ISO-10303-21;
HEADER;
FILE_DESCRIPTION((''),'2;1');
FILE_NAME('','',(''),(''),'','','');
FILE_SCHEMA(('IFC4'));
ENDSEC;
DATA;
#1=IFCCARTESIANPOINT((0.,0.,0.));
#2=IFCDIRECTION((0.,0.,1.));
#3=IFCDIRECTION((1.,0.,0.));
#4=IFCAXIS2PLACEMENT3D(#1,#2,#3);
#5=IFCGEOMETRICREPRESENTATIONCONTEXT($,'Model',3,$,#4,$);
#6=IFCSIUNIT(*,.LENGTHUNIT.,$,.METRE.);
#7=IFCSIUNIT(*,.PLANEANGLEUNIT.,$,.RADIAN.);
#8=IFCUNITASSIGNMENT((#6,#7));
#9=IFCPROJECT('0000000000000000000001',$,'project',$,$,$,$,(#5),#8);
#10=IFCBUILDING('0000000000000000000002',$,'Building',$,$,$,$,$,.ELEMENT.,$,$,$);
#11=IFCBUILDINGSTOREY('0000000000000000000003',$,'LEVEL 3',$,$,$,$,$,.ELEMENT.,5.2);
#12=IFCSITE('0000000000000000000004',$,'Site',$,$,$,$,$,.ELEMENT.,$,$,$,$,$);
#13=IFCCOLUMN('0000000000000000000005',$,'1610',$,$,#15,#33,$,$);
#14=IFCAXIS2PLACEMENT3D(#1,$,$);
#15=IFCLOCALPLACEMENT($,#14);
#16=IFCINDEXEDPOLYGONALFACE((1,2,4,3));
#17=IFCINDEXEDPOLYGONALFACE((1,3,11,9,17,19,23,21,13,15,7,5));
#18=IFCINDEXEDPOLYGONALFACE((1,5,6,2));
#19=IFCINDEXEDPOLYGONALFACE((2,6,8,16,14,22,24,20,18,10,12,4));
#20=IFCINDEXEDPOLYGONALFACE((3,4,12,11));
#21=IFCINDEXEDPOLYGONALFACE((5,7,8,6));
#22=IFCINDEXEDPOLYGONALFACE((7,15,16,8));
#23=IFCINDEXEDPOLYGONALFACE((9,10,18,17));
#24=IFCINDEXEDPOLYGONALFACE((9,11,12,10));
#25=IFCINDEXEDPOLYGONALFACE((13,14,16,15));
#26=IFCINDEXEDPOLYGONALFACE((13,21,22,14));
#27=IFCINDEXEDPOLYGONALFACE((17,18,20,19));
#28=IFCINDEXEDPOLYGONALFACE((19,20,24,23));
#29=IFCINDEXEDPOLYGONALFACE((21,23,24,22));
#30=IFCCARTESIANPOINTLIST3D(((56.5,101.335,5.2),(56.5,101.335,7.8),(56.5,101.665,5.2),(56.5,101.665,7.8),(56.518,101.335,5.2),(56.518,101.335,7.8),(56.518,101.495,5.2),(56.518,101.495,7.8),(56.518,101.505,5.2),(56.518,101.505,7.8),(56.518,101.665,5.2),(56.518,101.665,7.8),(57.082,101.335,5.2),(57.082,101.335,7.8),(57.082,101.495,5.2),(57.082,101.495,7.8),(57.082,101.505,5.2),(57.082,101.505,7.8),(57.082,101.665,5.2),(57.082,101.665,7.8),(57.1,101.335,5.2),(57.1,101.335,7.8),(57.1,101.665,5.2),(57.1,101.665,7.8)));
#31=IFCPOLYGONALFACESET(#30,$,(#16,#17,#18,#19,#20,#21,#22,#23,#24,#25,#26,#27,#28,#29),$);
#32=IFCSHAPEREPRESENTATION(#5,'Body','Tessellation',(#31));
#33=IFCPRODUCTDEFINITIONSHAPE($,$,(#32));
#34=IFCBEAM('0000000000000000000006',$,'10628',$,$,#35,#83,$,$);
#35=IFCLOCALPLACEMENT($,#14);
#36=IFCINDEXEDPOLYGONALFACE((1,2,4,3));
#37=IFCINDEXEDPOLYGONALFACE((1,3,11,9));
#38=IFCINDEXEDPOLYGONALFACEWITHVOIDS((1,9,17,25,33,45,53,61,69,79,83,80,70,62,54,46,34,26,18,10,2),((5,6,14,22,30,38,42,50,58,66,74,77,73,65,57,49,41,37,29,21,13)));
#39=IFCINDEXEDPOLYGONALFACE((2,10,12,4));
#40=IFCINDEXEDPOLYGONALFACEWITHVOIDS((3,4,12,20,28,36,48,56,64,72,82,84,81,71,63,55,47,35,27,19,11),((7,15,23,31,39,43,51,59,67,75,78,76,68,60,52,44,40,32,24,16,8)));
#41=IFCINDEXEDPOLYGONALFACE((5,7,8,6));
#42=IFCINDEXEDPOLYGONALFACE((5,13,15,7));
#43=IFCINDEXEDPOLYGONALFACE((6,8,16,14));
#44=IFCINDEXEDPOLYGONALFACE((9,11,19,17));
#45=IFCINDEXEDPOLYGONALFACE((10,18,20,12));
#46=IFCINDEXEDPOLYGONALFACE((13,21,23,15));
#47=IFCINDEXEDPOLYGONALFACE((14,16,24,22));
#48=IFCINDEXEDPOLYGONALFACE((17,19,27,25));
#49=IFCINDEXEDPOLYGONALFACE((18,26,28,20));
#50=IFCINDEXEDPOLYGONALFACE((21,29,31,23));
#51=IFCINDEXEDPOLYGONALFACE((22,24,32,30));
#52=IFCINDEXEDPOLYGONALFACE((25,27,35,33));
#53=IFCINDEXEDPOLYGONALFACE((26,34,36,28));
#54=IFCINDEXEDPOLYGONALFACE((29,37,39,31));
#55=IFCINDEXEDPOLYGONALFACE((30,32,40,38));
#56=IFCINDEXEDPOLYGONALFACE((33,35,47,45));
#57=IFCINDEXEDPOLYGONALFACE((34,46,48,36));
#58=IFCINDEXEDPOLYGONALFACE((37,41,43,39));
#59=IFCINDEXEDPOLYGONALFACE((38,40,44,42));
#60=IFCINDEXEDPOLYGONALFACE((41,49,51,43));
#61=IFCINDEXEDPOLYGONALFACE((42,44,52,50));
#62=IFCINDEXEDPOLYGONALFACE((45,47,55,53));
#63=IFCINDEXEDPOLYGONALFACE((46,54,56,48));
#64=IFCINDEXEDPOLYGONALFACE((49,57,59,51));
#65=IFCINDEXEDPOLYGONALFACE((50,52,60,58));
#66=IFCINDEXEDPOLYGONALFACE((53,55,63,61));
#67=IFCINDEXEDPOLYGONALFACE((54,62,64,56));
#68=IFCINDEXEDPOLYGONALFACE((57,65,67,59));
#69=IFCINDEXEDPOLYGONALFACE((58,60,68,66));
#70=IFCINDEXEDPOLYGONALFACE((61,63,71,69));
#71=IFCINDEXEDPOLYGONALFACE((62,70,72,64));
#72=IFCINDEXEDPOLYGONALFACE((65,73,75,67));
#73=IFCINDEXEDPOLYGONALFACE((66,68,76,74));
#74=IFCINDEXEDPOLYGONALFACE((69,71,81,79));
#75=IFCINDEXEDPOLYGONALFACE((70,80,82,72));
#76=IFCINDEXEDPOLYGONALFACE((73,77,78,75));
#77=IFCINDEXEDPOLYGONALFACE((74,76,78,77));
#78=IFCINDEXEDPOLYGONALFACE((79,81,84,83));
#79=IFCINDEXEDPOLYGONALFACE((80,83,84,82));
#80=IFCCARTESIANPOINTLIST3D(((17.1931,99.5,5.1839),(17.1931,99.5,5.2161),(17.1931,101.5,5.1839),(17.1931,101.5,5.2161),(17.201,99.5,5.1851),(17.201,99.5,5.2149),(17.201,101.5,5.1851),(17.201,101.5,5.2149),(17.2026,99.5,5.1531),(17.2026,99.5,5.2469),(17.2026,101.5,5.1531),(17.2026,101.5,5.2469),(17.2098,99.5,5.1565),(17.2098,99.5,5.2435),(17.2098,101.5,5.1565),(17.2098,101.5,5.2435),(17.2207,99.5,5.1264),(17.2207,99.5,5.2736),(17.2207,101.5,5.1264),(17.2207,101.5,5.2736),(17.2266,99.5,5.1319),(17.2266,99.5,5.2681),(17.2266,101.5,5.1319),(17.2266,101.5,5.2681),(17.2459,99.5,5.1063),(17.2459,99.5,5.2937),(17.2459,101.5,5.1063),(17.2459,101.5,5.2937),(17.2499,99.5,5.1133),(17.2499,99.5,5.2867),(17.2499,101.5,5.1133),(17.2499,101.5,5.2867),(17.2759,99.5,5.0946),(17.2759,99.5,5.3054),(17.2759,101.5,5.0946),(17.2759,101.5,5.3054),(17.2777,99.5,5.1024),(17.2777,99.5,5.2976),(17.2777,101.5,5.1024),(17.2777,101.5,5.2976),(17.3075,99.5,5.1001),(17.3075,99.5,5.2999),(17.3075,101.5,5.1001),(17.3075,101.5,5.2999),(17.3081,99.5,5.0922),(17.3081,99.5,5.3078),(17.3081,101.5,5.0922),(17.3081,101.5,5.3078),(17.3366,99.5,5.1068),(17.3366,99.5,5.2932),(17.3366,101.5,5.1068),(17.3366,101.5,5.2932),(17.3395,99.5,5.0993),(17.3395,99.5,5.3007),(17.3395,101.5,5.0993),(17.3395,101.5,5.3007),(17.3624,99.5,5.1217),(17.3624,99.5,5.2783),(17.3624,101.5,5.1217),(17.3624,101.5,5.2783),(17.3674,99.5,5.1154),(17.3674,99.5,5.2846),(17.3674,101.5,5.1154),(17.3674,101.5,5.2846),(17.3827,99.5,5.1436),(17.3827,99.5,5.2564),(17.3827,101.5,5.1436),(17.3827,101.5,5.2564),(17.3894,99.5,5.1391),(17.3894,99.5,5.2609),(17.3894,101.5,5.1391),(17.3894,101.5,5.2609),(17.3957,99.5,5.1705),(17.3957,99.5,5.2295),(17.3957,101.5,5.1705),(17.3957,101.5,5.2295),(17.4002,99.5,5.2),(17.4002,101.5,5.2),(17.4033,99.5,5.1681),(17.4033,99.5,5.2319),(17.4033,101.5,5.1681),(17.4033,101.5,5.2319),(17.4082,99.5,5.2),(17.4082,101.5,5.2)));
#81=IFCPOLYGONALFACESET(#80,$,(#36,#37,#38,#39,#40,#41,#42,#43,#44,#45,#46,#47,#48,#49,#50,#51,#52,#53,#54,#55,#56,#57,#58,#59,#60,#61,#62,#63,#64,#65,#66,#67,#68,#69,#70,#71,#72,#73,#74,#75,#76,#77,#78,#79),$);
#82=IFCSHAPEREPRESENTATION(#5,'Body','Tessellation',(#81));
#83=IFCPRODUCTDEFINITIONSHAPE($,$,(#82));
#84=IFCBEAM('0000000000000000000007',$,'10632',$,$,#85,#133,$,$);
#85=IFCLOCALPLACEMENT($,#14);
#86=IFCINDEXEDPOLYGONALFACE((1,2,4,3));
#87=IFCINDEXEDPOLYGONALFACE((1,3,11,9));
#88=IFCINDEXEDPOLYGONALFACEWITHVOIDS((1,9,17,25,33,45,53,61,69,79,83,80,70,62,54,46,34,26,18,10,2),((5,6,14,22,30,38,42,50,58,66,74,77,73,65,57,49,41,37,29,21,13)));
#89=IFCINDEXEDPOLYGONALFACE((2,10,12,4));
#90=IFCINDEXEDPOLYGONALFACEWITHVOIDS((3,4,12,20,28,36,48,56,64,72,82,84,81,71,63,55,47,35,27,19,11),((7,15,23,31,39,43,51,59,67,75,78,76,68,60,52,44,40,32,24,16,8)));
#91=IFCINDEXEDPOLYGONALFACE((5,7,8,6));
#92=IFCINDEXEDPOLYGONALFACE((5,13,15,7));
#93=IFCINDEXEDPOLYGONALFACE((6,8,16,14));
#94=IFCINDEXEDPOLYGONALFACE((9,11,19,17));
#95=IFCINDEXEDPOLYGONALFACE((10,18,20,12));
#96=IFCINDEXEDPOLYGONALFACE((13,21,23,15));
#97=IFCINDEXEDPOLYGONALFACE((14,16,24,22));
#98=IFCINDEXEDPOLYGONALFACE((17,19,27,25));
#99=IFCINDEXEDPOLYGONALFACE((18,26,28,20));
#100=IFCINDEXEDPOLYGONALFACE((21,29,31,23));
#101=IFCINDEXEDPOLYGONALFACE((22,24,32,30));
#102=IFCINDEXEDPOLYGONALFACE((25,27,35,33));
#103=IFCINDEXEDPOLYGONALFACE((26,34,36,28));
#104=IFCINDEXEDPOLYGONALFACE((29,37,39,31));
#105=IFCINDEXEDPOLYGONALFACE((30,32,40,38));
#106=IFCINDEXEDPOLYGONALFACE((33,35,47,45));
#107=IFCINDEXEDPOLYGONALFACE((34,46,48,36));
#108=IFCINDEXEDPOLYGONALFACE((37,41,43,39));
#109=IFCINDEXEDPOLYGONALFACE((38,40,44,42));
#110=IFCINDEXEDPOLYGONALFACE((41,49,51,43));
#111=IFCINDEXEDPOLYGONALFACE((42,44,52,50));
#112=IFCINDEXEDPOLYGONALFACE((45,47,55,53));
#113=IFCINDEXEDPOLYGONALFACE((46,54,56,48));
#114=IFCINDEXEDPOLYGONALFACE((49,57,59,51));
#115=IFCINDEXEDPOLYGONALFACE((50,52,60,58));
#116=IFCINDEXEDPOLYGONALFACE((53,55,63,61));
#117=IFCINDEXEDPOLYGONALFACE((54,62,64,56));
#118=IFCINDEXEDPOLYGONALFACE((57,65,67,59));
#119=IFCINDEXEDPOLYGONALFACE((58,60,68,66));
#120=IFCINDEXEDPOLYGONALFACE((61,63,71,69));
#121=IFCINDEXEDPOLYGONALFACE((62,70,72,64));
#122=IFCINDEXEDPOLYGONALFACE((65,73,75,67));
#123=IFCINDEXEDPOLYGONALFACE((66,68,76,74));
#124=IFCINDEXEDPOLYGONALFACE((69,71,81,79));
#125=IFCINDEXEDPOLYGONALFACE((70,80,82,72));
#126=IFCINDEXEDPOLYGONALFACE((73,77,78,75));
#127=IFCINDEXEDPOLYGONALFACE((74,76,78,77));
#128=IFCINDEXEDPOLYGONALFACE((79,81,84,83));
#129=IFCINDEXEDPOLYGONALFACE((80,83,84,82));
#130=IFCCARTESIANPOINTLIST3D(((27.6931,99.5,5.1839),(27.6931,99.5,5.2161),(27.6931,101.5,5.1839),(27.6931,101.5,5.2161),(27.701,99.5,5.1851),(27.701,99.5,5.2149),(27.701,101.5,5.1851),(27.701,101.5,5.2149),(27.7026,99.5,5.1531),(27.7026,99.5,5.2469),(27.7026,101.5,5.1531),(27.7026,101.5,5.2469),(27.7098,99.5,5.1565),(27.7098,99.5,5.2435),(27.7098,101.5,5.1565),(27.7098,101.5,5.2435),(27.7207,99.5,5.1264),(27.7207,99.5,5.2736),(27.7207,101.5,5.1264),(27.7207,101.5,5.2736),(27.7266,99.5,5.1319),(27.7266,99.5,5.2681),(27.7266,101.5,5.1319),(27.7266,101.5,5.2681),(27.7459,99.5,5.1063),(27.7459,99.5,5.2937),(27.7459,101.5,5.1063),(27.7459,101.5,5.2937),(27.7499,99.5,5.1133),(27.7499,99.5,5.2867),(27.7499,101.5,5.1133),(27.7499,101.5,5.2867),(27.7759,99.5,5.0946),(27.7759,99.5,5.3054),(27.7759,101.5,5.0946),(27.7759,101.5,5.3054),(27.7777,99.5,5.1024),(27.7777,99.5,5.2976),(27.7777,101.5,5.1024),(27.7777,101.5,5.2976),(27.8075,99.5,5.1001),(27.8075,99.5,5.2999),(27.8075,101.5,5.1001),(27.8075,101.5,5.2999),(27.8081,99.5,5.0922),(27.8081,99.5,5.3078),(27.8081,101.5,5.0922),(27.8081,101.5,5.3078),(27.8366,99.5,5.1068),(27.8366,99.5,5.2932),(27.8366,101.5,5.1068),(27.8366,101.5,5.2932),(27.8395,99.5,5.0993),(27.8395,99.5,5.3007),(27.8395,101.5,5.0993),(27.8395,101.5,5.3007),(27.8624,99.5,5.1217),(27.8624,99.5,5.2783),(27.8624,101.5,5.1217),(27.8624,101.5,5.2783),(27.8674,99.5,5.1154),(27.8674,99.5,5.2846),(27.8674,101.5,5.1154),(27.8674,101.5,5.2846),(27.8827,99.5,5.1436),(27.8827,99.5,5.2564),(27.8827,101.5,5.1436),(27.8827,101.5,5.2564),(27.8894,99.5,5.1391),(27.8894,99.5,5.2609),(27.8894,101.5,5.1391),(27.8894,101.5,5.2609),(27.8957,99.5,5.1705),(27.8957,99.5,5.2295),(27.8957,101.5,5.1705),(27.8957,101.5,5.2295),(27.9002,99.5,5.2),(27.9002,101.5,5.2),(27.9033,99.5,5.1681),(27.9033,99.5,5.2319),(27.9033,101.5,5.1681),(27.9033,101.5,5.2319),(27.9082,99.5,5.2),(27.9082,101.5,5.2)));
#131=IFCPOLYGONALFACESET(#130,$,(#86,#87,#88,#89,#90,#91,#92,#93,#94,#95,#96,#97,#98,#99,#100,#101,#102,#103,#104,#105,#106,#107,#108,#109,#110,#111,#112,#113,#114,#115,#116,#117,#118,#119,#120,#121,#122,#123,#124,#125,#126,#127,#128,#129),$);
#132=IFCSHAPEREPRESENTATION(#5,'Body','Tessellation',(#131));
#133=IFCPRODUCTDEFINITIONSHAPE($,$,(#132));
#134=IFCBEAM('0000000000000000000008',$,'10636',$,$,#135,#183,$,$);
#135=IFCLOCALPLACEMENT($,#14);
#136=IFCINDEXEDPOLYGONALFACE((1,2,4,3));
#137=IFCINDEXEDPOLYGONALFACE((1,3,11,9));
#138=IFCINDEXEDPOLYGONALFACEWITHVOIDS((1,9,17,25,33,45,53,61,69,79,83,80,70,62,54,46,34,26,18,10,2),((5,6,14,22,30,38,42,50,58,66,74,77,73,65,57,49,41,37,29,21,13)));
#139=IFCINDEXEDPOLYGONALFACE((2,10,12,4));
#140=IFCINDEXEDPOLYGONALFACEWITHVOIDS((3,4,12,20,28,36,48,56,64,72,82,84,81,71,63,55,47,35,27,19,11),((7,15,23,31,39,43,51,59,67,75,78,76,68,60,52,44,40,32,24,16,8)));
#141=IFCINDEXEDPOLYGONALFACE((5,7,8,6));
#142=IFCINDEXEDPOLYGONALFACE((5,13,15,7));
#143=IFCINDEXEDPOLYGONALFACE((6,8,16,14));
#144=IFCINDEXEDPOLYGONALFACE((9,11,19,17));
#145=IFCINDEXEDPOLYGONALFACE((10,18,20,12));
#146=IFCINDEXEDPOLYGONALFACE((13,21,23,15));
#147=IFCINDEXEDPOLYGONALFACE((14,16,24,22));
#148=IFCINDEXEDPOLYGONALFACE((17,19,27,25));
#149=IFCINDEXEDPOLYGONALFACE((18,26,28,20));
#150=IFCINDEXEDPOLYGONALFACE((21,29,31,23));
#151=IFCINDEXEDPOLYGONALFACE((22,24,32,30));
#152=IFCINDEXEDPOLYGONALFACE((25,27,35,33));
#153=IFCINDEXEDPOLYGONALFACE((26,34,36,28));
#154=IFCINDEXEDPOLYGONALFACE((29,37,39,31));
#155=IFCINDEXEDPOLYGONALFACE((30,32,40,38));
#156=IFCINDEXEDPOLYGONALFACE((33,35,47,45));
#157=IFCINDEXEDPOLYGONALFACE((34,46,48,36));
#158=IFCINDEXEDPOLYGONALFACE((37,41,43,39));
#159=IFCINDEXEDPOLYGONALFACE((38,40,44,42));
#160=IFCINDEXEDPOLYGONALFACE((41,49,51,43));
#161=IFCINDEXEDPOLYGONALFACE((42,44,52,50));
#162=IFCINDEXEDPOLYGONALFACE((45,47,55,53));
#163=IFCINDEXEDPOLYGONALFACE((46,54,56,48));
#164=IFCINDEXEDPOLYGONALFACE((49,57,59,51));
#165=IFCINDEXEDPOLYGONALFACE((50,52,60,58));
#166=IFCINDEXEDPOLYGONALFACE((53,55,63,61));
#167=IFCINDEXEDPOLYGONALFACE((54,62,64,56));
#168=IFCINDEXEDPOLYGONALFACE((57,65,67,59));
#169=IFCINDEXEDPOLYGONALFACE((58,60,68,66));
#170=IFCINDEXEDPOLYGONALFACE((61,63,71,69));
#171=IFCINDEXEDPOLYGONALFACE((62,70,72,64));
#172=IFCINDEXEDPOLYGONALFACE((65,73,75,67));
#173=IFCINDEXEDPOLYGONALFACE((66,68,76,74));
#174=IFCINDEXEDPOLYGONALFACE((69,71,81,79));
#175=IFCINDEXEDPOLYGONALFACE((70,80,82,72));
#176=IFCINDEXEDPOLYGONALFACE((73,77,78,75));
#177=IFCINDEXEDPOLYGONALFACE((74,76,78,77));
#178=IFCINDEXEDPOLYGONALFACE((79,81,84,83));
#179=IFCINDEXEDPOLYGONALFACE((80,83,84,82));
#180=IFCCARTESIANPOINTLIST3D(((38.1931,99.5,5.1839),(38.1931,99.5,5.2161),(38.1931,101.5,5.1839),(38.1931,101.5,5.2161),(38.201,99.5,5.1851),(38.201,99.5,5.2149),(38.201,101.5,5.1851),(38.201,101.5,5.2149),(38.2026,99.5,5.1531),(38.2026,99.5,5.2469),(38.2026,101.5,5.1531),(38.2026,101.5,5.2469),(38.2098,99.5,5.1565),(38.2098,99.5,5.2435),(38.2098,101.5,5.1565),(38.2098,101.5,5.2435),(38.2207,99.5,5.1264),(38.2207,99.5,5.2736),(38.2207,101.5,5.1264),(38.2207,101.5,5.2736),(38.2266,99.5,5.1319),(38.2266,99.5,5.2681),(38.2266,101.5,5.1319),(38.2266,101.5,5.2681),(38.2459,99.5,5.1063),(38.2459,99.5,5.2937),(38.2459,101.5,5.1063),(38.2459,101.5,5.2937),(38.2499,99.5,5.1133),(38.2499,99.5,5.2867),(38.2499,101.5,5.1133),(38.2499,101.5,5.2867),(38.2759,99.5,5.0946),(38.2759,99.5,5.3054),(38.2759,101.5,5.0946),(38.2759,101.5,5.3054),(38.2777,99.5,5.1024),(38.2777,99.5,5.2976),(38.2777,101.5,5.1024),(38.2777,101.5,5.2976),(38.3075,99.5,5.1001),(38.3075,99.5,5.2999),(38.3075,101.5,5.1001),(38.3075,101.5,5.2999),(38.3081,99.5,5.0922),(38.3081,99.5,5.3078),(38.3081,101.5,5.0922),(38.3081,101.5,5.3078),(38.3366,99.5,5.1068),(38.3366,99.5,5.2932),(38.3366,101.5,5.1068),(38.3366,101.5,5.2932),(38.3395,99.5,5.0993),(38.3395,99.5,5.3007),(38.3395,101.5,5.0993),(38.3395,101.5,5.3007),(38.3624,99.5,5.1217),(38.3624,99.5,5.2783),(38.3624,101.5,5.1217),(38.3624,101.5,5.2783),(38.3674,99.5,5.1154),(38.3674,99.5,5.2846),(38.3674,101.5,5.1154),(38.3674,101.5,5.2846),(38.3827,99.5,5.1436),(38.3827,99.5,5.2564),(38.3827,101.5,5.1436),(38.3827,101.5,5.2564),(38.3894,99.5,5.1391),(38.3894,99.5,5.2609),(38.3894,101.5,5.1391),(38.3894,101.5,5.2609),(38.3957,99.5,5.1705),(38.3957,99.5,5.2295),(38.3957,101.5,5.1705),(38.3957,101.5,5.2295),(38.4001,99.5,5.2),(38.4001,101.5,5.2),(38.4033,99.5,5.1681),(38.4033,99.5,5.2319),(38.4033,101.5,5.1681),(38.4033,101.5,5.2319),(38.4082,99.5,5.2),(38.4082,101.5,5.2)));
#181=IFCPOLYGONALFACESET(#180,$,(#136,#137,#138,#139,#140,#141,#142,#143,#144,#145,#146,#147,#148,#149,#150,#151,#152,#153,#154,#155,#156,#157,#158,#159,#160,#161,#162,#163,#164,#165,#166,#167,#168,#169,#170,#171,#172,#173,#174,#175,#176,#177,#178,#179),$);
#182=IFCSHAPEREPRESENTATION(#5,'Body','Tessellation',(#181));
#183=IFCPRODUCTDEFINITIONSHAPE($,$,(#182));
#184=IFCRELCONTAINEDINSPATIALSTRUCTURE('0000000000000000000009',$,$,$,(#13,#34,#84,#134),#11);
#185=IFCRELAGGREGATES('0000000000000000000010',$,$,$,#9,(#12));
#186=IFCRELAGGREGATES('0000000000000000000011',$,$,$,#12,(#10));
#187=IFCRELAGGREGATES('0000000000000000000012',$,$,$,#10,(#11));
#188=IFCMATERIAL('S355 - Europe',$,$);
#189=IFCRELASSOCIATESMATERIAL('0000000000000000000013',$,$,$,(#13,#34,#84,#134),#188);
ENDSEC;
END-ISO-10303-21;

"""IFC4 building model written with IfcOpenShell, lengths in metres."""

from ifc_helpers import new_model, si_unit, frame, origin_with_axes, origin_2d_with_axis, place, context, project, spatial, hollow_circle, i_section, extrude, material, material_profile, profile_set, profile_usage, element, save


model = new_model("IFC4")

# Units and contexts
model_context = context("Model", 3, world=origin_with_axes())
ifc_project = project(units=[si_unit("LENGTHUNIT", "METRE"), si_unit("PLANEANGLEUNIT", "RADIAN")], contexts=[model_context])

# Site, building, storey
site = spatial("IfcSite", under=ifc_project, Name="Site", CompositionType="ELEMENT")
building = spatial("IfcBuilding", under=site, Name="Building", CompositionType="ELEMENT")
storey = spatial("IfcBuildingStorey", under=building, Name="LEVEL 3", CompositionType="ELEMENT", Elevation=5.2)

# Column
ifc_material = material(Name="S355 - Europe")
ifc_material_profile_1 = material_profile(ifc_material, i_section(OverallWidth=0.33, OverallDepth=0.6, WebThickness=0.01, FlangeThickness=0.018, at=origin_2d_with_axis()))
ifc_profile_set_1 = profile_set([ifc_material_profile_1])
ifc_profile_usage_1 = profile_usage(ifc_profile_set_1, cardinal=10)
column_1_placement = place(None, frame((56.8, 101.5, 5.2), z_axis=(0.0, 0.0, 1.0), x_axis=(0.0, -1.0, 0.0)))
element("IfcColumn", 1, at=column_1_placement, inside=storey, material=ifc_profile_usage_1, Name="1610", context=model_context, shape_type="SweptSolid", body=[
    extrude(i_section(OverallWidth=0.33, OverallDepth=0.6, WebThickness=0.01, FlangeThickness=0.018, at=origin_2d_with_axis()), origin_with_axes(), (0.0, 0.0, 1.0), 2.6),
])

# Beams
ifc_material_profile_2 = material_profile(ifc_material, hollow_circle(Radius=0.1081, WallThickness=0.008, at=origin_2d_with_axis()))
ifc_profile_set_2 = profile_set([ifc_material_profile_2])
ifc_profile_usage_2 = profile_usage(ifc_profile_set_2, cardinal=10)
beam_1_placement = place(None, frame((17.3, 101.5, 5.2), z_axis=(0.0, -1.0, 0.0), x_axis=(1.0, 0.0, 0.0)))
element("IfcBeam", 2, at=beam_1_placement, inside=storey, material=ifc_profile_usage_2, Name="10628", context=model_context, shape_type="SweptSolid", body=[
    extrude(hollow_circle(Radius=0.1081, WallThickness=0.008, at=origin_2d_with_axis()), origin_with_axes(), (0.0, 0.0, 1.0), 2.0),
])
ifc_material_profile_3 = material_profile(ifc_material, hollow_circle(Radius=0.1081, WallThickness=0.008, at=origin_2d_with_axis()))
ifc_profile_set_3 = profile_set([ifc_material_profile_3])
ifc_profile_usage_3 = profile_usage(ifc_profile_set_3, cardinal=10)
beam_2_placement = place(None, frame((27.8, 101.5, 5.2), z_axis=(0.0, -1.0, 0.0), x_axis=(1.0, 0.0, 0.0)))
element("IfcBeam", 3, at=beam_2_placement, inside=storey, material=ifc_profile_usage_3, Name="10632", context=model_context, shape_type="SweptSolid", body=[
    extrude(hollow_circle(Radius=0.1081, WallThickness=0.008, at=origin_2d_with_axis()), origin_with_axes(), (0.0, 0.0, 1.0), 2.0),
])
ifc_material_profile_4 = material_profile(ifc_material, hollow_circle(Radius=0.1081, WallThickness=0.008, at=origin_2d_with_axis()))
ifc_profile_set_4 = profile_set([ifc_material_profile_4])
ifc_profile_usage_4 = profile_usage(ifc_profile_set_4, cardinal=10)
beam_3_placement = place(None, frame((38.3, 101.5, 5.2), z_axis=(0.0, -1.0, 0.0), x_axis=(1.0, 0.0, 0.0)))
element("IfcBeam", 4, at=beam_3_placement, inside=storey, material=ifc_profile_usage_4, Name="10636", context=model_context, shape_type="SweptSolid", body=[
    extrude(hollow_circle(Radius=0.1081, WallThickness=0.008, at=origin_2d_with_axis()), origin_with_axes(), (0.0, 0.0, 1.0), 2.0),
])

save(model, "model.ifc")
